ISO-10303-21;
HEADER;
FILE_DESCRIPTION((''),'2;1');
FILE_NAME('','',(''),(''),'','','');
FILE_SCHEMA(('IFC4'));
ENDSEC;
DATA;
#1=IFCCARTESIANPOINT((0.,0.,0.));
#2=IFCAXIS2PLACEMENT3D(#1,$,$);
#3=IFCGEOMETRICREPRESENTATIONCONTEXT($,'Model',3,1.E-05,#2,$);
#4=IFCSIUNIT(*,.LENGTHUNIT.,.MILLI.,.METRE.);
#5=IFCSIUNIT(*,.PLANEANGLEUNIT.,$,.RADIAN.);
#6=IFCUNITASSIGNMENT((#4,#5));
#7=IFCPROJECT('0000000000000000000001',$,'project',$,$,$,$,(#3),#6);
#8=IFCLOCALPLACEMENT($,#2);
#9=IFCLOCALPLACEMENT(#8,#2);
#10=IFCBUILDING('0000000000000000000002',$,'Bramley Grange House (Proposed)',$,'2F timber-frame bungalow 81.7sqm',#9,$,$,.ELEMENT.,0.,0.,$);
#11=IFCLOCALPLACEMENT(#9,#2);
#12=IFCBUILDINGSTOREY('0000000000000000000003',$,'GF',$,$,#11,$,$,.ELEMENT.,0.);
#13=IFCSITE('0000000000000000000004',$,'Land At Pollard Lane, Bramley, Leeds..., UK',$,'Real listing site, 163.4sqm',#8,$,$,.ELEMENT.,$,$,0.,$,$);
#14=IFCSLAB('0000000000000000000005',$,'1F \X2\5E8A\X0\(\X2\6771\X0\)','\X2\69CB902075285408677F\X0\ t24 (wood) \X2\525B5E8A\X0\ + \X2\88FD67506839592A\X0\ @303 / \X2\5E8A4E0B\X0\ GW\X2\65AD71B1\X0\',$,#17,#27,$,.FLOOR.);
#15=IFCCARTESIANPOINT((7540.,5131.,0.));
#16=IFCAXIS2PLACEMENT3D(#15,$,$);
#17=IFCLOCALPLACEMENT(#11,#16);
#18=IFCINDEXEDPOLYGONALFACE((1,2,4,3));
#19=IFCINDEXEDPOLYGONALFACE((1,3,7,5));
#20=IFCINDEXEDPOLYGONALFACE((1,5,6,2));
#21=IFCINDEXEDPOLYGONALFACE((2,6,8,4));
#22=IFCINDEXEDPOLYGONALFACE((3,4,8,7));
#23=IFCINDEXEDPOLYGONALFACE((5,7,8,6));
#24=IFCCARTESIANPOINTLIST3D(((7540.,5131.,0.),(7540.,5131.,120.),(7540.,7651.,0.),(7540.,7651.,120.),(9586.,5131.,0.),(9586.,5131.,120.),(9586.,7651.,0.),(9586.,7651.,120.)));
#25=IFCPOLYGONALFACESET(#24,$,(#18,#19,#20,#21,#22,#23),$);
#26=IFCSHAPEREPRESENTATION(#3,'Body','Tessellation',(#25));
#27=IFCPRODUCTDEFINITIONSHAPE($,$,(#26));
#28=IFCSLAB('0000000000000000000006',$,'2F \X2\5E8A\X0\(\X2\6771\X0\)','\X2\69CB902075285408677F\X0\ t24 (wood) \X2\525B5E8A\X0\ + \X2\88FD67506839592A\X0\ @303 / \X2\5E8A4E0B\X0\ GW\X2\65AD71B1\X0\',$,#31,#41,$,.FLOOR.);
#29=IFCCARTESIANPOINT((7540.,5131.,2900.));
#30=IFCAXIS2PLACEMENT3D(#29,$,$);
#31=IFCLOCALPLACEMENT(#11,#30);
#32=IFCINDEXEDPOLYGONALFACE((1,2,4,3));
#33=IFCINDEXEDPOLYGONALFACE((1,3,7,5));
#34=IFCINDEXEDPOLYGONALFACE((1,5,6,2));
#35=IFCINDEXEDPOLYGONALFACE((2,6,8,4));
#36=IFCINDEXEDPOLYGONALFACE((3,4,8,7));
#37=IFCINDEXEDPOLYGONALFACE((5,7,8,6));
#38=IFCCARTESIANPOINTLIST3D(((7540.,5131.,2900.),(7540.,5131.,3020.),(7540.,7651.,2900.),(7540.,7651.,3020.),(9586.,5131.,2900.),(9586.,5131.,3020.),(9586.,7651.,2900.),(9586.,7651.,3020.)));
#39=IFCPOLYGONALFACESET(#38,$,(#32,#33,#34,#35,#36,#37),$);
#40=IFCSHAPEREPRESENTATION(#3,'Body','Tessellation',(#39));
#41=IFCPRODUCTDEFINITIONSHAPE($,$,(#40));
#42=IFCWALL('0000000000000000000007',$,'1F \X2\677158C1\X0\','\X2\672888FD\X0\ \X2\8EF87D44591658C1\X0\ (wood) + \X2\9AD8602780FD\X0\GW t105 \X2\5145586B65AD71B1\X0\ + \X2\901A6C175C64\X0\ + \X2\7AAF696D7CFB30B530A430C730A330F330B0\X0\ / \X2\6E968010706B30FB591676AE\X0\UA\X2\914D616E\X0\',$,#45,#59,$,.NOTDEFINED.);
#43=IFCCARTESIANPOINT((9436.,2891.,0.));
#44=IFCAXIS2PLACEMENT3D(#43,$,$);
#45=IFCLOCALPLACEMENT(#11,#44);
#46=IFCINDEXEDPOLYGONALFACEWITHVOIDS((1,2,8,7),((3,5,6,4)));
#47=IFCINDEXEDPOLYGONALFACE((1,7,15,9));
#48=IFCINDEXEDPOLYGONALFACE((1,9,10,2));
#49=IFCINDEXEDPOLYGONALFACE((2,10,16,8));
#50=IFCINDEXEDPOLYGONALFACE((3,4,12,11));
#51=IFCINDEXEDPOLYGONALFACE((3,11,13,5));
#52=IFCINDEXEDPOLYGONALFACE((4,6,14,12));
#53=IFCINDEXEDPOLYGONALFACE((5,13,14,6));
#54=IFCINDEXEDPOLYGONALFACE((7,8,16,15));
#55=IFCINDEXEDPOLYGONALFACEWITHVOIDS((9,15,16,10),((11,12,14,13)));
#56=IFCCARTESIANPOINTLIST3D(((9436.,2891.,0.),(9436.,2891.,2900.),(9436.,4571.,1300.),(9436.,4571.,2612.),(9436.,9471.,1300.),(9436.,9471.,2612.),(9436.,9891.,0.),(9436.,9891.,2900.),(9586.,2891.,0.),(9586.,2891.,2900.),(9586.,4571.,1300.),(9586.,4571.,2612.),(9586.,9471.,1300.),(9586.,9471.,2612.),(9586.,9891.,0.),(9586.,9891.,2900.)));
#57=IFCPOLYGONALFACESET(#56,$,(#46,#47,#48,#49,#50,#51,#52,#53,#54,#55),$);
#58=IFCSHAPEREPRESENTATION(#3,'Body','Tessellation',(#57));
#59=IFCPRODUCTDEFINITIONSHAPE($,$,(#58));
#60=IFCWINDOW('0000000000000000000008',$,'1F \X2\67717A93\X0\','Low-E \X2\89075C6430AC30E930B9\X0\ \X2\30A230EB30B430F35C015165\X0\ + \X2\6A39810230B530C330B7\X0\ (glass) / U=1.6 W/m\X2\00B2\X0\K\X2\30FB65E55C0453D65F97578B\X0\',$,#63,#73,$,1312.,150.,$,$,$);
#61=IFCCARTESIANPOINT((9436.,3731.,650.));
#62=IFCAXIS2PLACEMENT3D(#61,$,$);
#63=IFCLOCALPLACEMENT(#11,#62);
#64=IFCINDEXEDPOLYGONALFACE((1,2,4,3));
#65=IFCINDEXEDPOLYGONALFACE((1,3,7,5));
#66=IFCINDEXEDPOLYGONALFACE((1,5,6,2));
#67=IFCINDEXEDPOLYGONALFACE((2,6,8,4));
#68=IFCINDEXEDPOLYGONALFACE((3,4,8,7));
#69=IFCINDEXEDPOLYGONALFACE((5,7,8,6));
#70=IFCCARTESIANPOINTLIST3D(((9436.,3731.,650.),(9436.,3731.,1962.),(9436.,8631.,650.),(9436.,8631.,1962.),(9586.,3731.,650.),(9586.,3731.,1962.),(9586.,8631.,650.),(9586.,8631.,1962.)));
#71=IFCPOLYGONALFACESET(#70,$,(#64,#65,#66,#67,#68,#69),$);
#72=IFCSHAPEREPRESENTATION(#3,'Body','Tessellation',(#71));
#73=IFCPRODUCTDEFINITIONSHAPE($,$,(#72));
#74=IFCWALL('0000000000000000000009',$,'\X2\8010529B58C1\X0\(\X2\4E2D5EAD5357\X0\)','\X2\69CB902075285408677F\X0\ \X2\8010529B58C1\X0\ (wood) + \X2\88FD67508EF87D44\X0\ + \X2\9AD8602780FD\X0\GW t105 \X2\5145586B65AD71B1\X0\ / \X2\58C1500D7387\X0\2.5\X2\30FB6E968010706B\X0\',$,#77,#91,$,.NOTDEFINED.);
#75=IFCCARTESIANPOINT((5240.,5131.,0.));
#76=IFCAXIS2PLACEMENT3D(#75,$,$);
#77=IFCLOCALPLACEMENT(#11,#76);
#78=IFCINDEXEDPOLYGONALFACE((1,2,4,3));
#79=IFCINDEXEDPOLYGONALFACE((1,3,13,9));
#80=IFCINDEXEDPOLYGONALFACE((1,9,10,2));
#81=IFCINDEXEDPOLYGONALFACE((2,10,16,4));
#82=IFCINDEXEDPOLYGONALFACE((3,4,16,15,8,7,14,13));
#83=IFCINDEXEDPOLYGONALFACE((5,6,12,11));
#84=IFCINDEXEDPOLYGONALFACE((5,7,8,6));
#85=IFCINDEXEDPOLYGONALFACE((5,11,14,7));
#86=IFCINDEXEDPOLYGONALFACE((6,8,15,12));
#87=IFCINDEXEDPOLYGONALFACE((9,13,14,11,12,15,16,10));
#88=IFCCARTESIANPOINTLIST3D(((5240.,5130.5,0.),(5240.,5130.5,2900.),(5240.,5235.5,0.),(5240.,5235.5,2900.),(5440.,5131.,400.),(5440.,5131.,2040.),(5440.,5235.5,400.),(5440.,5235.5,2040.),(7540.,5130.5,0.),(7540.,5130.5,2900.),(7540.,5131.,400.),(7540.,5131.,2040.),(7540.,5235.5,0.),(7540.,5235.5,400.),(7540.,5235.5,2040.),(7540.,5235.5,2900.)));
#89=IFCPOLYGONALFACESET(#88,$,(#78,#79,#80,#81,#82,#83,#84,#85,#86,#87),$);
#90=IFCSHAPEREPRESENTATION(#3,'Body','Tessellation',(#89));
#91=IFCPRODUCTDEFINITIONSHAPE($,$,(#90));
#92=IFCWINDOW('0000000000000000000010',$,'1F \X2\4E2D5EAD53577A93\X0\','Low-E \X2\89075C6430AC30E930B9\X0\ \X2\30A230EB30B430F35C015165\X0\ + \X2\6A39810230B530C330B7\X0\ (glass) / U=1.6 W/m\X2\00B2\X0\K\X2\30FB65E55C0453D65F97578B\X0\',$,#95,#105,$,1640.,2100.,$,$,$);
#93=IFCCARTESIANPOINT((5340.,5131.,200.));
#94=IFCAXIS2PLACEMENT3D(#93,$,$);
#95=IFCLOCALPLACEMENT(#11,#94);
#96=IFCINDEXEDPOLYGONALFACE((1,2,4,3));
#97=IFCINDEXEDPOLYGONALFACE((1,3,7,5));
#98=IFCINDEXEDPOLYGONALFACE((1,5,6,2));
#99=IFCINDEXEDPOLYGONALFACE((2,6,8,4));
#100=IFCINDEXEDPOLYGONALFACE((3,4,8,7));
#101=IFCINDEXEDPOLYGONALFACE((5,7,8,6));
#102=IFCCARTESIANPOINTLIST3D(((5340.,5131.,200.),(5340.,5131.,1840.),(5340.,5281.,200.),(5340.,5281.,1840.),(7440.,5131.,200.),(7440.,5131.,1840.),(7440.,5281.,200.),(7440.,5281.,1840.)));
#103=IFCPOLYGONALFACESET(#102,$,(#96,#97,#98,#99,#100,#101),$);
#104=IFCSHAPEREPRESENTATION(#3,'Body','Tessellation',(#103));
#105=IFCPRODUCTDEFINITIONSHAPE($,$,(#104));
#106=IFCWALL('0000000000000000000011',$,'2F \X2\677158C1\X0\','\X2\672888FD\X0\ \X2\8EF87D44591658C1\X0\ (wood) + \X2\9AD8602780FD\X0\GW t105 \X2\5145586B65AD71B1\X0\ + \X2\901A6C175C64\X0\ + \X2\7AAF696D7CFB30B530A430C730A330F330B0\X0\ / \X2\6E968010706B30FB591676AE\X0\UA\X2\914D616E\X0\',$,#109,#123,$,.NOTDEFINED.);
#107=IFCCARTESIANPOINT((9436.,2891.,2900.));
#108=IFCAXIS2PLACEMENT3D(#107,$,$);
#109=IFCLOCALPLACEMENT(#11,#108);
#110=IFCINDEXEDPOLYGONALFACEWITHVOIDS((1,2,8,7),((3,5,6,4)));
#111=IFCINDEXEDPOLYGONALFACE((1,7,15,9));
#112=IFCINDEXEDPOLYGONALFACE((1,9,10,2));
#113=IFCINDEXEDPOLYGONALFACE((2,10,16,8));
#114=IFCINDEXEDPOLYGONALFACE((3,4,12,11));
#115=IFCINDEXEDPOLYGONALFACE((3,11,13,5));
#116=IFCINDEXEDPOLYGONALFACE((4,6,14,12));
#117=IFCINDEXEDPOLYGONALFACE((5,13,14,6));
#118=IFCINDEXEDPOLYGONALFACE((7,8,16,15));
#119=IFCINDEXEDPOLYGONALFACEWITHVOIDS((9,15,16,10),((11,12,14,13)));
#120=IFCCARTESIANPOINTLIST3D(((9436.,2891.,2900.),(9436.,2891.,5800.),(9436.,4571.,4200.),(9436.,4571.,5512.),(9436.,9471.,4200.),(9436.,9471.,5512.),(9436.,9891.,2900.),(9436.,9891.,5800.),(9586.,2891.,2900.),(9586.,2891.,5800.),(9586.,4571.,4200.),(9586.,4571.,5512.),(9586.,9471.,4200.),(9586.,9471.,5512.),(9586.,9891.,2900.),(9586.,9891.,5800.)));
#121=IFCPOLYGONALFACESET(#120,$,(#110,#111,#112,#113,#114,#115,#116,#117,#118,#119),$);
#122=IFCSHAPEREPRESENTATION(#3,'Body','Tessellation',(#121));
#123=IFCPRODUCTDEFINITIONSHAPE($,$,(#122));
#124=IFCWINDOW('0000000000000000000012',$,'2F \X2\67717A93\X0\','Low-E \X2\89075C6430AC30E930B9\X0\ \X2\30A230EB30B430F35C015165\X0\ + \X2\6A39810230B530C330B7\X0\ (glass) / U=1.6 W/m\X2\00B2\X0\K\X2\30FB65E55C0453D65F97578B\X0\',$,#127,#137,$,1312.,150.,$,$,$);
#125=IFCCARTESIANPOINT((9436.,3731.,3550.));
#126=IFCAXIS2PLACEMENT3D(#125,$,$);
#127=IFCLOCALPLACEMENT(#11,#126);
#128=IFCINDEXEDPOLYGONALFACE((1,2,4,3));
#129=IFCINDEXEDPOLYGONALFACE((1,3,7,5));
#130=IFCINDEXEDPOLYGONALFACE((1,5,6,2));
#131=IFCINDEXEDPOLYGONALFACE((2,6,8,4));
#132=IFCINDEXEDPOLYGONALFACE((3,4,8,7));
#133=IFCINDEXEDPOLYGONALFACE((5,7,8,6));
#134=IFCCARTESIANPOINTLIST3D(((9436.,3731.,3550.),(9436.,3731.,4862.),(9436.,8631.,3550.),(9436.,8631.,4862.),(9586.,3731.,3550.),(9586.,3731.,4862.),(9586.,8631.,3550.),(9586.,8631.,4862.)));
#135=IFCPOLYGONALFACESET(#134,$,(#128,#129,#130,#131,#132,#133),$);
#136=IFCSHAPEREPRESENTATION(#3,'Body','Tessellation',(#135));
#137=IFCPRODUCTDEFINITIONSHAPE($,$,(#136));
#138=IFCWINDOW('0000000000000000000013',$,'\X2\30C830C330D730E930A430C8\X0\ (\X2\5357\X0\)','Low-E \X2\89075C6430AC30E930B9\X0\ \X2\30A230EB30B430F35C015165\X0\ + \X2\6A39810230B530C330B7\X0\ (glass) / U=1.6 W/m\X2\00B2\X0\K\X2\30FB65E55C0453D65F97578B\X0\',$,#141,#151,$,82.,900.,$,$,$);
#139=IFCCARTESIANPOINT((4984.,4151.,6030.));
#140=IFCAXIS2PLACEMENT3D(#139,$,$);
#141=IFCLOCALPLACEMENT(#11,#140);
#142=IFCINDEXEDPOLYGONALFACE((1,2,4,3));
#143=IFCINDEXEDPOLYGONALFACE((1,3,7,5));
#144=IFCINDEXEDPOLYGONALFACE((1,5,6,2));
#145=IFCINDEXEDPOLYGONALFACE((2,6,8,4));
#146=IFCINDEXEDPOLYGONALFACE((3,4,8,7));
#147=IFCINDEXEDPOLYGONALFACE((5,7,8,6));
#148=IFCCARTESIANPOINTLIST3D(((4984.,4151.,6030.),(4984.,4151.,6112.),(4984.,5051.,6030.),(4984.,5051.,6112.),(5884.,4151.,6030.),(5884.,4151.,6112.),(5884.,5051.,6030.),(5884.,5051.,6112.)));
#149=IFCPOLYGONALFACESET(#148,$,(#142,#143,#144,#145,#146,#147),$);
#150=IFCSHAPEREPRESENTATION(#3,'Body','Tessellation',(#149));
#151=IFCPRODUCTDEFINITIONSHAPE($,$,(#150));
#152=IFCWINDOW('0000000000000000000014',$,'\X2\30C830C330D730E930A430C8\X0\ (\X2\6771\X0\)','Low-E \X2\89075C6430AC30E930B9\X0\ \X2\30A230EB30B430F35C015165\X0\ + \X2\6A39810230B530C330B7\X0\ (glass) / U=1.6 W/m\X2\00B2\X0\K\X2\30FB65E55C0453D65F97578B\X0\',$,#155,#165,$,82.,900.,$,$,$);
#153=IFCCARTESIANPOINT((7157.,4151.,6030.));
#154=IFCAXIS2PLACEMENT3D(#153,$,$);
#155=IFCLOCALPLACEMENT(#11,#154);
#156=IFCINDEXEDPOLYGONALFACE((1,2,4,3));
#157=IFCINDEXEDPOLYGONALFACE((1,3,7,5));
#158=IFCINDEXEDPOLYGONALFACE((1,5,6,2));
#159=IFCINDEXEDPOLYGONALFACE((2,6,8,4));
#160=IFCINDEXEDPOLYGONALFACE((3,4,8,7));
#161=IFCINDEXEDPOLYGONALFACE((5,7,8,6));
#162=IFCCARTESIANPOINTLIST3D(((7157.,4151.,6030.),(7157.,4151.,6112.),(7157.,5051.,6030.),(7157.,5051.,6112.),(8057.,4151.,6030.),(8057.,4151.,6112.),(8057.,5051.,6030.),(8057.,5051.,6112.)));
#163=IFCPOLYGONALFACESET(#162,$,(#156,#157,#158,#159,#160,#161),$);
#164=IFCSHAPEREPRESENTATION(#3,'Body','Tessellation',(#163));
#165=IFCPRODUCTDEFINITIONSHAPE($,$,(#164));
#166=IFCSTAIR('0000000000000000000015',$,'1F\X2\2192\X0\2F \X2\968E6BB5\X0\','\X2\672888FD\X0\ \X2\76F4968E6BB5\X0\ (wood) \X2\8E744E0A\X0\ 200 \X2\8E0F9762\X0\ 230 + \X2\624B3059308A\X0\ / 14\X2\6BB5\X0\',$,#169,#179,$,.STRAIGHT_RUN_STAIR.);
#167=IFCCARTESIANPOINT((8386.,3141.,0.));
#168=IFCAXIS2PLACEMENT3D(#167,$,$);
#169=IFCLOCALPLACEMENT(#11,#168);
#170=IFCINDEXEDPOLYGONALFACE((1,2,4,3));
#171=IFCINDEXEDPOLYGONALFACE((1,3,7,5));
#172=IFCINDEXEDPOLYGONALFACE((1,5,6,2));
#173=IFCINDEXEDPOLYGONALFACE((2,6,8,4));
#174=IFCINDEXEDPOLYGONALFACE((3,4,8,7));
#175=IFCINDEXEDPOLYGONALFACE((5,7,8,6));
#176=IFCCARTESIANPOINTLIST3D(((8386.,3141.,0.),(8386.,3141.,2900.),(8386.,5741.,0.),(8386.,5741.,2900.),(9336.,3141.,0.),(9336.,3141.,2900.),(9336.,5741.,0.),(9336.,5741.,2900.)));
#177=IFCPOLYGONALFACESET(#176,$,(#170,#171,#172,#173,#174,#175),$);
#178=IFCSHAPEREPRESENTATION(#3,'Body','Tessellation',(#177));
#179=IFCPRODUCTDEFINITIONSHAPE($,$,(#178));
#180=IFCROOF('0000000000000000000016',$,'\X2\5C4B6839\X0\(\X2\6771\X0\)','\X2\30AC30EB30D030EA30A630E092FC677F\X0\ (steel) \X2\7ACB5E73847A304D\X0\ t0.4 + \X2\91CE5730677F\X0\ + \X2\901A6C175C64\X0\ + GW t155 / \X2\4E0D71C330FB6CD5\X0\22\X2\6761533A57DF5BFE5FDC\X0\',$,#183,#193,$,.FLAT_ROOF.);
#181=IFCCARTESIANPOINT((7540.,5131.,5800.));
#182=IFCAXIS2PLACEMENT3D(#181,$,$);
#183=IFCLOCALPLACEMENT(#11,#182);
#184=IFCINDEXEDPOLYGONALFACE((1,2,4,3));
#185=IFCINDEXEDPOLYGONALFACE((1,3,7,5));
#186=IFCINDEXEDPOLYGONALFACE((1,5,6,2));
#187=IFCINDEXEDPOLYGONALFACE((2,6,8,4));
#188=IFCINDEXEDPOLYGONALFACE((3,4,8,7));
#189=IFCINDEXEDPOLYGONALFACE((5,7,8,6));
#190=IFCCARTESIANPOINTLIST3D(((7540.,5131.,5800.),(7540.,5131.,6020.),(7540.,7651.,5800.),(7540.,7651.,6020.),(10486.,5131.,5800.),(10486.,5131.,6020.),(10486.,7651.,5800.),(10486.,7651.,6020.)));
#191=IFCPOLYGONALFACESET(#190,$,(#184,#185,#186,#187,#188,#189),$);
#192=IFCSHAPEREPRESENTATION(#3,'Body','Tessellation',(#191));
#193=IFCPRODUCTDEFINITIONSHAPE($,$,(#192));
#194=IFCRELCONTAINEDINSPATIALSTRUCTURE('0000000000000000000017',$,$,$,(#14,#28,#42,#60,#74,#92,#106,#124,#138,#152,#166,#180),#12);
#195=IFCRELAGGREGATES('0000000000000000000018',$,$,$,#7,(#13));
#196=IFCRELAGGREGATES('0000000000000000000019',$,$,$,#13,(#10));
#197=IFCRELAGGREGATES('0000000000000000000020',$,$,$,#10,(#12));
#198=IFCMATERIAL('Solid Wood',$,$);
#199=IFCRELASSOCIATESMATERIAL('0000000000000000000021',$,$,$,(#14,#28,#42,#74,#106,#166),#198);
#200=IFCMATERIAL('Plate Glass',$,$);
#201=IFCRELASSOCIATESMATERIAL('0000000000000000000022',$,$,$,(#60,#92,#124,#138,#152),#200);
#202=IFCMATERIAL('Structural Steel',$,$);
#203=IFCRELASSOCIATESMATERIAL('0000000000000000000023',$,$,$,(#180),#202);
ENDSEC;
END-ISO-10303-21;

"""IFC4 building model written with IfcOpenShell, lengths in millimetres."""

from ifc_helpers import new_model, si_unit, frame, frame_2d, origin, place, context, project, spatial, rectangle, extrude, material, element, fill, save


model = new_model("IFC4")

# Units and contexts
model_context = context("Model", 3, precision=1e-05, world=origin())
ifc_project = project(units=[si_unit("LENGTHUNIT", "METRE", prefix="MILLI"), si_unit("PLANEANGLEUNIT", "RADIAN")], contexts=[model_context])

# Site, building, storey
site_placement = place(None, origin())
site = spatial("IfcSite", under=ifc_project, at=site_placement, Name="Land At Pollard Lane, Bramley, Leeds..., UK", ObjectType="Real listing site, 163.4sqm", CompositionType="ELEMENT", RefElevation=0.0)
building_placement = place(site_placement, origin())
building = spatial("IfcBuilding", under=site, at=building_placement, Name="Bramley Grange House (Proposed)", ObjectType="2F timber-frame bungalow 81.7sqm", CompositionType="ELEMENT", ElevationOfRefHeight=0.0, ElevationOfTerrain=0.0)
storey_placement = place(building_placement, origin())
storey = spatial("IfcBuildingStorey", under=building, at=storey_placement, Name="GF", CompositionType="ELEMENT", Elevation=0.0)

# Slabs
ifc_material_1 = material(Name="Solid Wood")
slab_1_placement = place(storey_placement, frame((7540.0, 5131.0, 0.0)))
element("IfcSlab", 1, at=slab_1_placement, inside=storey, material=ifc_material_1, Name="1F 床(東)", Description="構造用合板 t24 (wood) 剛床 + 製材根太 @303 / 床下 GW断熱", PredefinedType="FLOOR", context=model_context, shape_type="SweptSolid", body=[
    extrude(rectangle(XDim=2046.0, YDim=2520.0, at=frame_2d((1023.0, 1260.0))), frame((7540.0, 5131.0, 0.0)), (0.0, 0.0, 1.0), 120.0),
])
slab_2_placement = place(storey_placement, frame((7540.0, 5131.0, 2900.0)))
element("IfcSlab", 2, at=slab_2_placement, inside=storey, material=ifc_material_1, Name="2F 床(東)", Description="構造用合板 t24 (wood) 剛床 + 製材根太 @303 / 床下 GW断熱", PredefinedType="FLOOR", context=model_context, shape_type="SweptSolid", body=[
    extrude(rectangle(XDim=2046.0, YDim=2520.0, at=frame_2d((1023.0, 1260.0))), frame((7540.0, 5131.0, 2900.0)), (0.0, 0.0, 1.0), 120.0),
])

# Walls, openings, windows
wall_1_placement = place(storey_placement, frame((9436.0, 2891.0, 0.0)))
wall_1 = element("IfcWall", 3, at=wall_1_placement, inside=storey, material=ifc_material_1, Name="1F 東壁", Description="木製 軸組外壁 (wood) + 高性能GW t105 充填断熱 + 通気層 + 窯業系サイディング / 準耐火・外皮UA配慮", PredefinedType="NOTDEFINED", context=model_context, shape_type="SweptSolid", body=[
    extrude(rectangle(XDim=150.0, YDim=7000.0, at=frame_2d((75.0, 3500.0))), frame((9436.0, 2891.0, 0.0)), (0.0, 0.0, 1.0), 2900.0),
])
opening_1_placement = place(storey_placement, frame((9436.0, 3731.0, 650.0)))
opening_1 = element("IfcOpeningElement", 4, at=opening_1_placement, cuts=wall_1, PredefinedType="NOTDEFINED", context=model_context, shape_type="SweptSolid", body=[
    extrude(rectangle(XDim=150.0, YDim=4900.0, at=frame_2d((75.0, 2450.0))), frame((9436.0, 3731.0, 650.0)), (0.0, 0.0, 1.0), 1312.0),
])
ifc_material_2 = material(Name="Plate Glass")
window_1_placement = place(storey_placement, frame((9436.0, 3731.0, 650.0)))
window_1 = element("IfcWindow", 5, at=window_1_placement, inside=storey, material=ifc_material_2, Name="1F 東窓", Description="Low-E 複層ガラス アルゴン封入 + 樹脂サッシ (glass) / U=1.6 W/m²K・日射取得型", OverallHeight=1312.0, OverallWidth=150.0, context=model_context, shape_type="SweptSolid", body=[
    extrude(rectangle(XDim=150.0, YDim=4900.0, at=frame_2d((75.0, 2450.0))), frame((9436.0, 3731.0, 650.0)), (0.0, 0.0, 1.0), 1312.0),
])
fill(opening_1, window_1)
wall_2_placement = place(storey_placement, frame((5240.0, 5131.0, 0.0)))
wall_2 = element("IfcWall", 6, at=wall_2_placement, inside=storey, material=ifc_material_1, Name="耐力壁(中庭南)", Description="構造用合板 耐力壁 (wood) + 製材軸組 + 高性能GW t105 充填断熱 / 壁倍率2.5・準耐火", PredefinedType="NOTDEFINED", context=model_context, shape_type="SweptSolid", body=[
    extrude(rectangle(XDim=2300.0, YDim=105.0, at=frame_2d((1150.0, 52.0))), frame((5240.0, 5131.0, 0.0)), (0.0, 0.0, 1.0), 2900.0),
])
opening_2_placement = place(storey_placement, frame((5340.0, 5131.0, 200.0)))
opening_2 = element("IfcOpeningElement", 7, at=opening_2_placement, cuts=wall_2, PredefinedType="NOTDEFINED", context=model_context, shape_type="SweptSolid", body=[
    extrude(rectangle(XDim=2100.0, YDim=150.0, at=frame_2d((1050.0, 75.0))), frame((5340.0, 5131.0, 200.0)), (0.0, 0.0, 1.0), 1640.0),
])
window_2_placement = place(storey_placement, frame((5340.0, 5131.0, 200.0)))
window_2 = element("IfcWindow", 8, at=window_2_placement, inside=storey, material=ifc_material_2, Name="1F 中庭南窓", Description="Low-E 複層ガラス アルゴン封入 + 樹脂サッシ (glass) / U=1.6 W/m²K・日射取得型", OverallHeight=1640.0, OverallWidth=2100.0, context=model_context, shape_type="SweptSolid", body=[
    extrude(rectangle(XDim=2100.0, YDim=150.0, at=frame_2d((1050.0, 75.0))), frame((5340.0, 5131.0, 200.0)), (0.0, 0.0, 1.0), 1640.0),
])
fill(opening_2, window_2)

# Wall, opening, window
wall_3_placement = place(storey_placement, frame((9436.0, 2891.0, 2900.0)))
wall_3 = element("IfcWall", 9, at=wall_3_placement, inside=storey, material=ifc_material_1, Name="2F 東壁", Description="木製 軸組外壁 (wood) + 高性能GW t105 充填断熱 + 通気層 + 窯業系サイディング / 準耐火・外皮UA配慮", PredefinedType="NOTDEFINED", context=model_context, shape_type="SweptSolid", body=[
    extrude(rectangle(XDim=150.0, YDim=7000.0, at=frame_2d((75.0, 3500.0))), frame((9436.0, 2891.0, 2900.0)), (0.0, 0.0, 1.0), 2900.0),
])
opening_3_placement = place(storey_placement, frame((9436.0, 3731.0, 3550.0)))
opening_3 = element("IfcOpeningElement", 10, at=opening_3_placement, cuts=wall_3, PredefinedType="NOTDEFINED", context=model_context, shape_type="SweptSolid", body=[
    extrude(rectangle(XDim=150.0, YDim=4900.0, at=frame_2d((75.0, 2450.0))), frame((9436.0, 3731.0, 3550.0)), (0.0, 0.0, 1.0), 1312.0),
])
window_3_placement = place(storey_placement, frame((9436.0, 3731.0, 3550.0)))
window_3 = element("IfcWindow", 11, at=window_3_placement, inside=storey, material=ifc_material_2, Name="2F 東窓", Description="Low-E 複層ガラス アルゴン封入 + 樹脂サッシ (glass) / U=1.6 W/m²K・日射取得型", OverallHeight=1312.0, OverallWidth=150.0, context=model_context, shape_type="SweptSolid", body=[
    extrude(rectangle(XDim=150.0, YDim=4900.0, at=frame_2d((75.0, 2450.0))), frame((9436.0, 3731.0, 3550.0)), (0.0, 0.0, 1.0), 1312.0),
])
fill(opening_3, window_3)

# Windows
window_4_placement = place(storey_placement, frame((4984.0, 4151.0, 6030.0)))
element("IfcWindow", 12, at=window_4_placement, inside=storey, material=ifc_material_2, Name="トップライト (南)", Description="Low-E 複層ガラス アルゴン封入 + 樹脂サッシ (glass) / U=1.6 W/m²K・日射取得型", OverallHeight=82.0, OverallWidth=900.0, context=model_context, shape_type="SweptSolid", body=[
    extrude(rectangle(XDim=900.0, YDim=900.0, at=frame_2d((450.0, 450.0))), frame((4984.0, 4151.0, 6030.0)), (0.0, 0.0, 1.0), 82.0),
])
window_5_placement = place(storey_placement, frame((7157.0, 4151.0, 6030.0)))
element("IfcWindow", 13, at=window_5_placement, inside=storey, material=ifc_material_2, Name="トップライト (東)", Description="Low-E 複層ガラス アルゴン封入 + 樹脂サッシ (glass) / U=1.6 W/m²K・日射取得型", OverallHeight=82.0, OverallWidth=900.0, context=model_context, shape_type="SweptSolid", body=[
    extrude(rectangle(XDim=900.0, YDim=900.0, at=frame_2d((450.0, 450.0))), frame((7157.0, 4151.0, 6030.0)), (0.0, 0.0, 1.0), 82.0),
])

# Stair
stair_placement = place(storey_placement, frame((8386.0, 3141.0, 0.0)))
element("IfcStair", 14, at=stair_placement, inside=storey, material=ifc_material_1, Name="1F→2F 階段", Description="木製 直階段 (wood) 蹴上 200 踏面 230 + 手すり / 14段", PredefinedType="STRAIGHT_RUN_STAIR", context=model_context, shape_type="SweptSolid", body=[
    extrude(rectangle(XDim=950.0, YDim=2600.0, at=frame_2d((475.0, 1300.0))), frame((8386.0, 3141.0, 0.0)), (0.0, 0.0, 1.0), 2900.0),
])

# Roof
ifc_material_3 = material(Name="Structural Steel")
roof_placement = place(storey_placement, frame((7540.0, 5131.0, 5800.0)))
element("IfcRoof", 15, at=roof_placement, inside=storey, material=ifc_material_3, Name="屋根(東)", Description="ガルバリウム鋼板 (steel) 立平葺き t0.4 + 野地板 + 通気層 + GW t155 / 不燃・法22条区域対応", PredefinedType="FLAT_ROOF", context=model_context, shape_type="SweptSolid", body=[
    extrude(rectangle(XDim=2946.0, YDim=2520.0, at=frame_2d((1473.0, 1260.0))), frame((7540.0, 5131.0, 5800.0)), (0.0, 0.0, 1.0), 220.0),
])

save(model, "model.ifc")
